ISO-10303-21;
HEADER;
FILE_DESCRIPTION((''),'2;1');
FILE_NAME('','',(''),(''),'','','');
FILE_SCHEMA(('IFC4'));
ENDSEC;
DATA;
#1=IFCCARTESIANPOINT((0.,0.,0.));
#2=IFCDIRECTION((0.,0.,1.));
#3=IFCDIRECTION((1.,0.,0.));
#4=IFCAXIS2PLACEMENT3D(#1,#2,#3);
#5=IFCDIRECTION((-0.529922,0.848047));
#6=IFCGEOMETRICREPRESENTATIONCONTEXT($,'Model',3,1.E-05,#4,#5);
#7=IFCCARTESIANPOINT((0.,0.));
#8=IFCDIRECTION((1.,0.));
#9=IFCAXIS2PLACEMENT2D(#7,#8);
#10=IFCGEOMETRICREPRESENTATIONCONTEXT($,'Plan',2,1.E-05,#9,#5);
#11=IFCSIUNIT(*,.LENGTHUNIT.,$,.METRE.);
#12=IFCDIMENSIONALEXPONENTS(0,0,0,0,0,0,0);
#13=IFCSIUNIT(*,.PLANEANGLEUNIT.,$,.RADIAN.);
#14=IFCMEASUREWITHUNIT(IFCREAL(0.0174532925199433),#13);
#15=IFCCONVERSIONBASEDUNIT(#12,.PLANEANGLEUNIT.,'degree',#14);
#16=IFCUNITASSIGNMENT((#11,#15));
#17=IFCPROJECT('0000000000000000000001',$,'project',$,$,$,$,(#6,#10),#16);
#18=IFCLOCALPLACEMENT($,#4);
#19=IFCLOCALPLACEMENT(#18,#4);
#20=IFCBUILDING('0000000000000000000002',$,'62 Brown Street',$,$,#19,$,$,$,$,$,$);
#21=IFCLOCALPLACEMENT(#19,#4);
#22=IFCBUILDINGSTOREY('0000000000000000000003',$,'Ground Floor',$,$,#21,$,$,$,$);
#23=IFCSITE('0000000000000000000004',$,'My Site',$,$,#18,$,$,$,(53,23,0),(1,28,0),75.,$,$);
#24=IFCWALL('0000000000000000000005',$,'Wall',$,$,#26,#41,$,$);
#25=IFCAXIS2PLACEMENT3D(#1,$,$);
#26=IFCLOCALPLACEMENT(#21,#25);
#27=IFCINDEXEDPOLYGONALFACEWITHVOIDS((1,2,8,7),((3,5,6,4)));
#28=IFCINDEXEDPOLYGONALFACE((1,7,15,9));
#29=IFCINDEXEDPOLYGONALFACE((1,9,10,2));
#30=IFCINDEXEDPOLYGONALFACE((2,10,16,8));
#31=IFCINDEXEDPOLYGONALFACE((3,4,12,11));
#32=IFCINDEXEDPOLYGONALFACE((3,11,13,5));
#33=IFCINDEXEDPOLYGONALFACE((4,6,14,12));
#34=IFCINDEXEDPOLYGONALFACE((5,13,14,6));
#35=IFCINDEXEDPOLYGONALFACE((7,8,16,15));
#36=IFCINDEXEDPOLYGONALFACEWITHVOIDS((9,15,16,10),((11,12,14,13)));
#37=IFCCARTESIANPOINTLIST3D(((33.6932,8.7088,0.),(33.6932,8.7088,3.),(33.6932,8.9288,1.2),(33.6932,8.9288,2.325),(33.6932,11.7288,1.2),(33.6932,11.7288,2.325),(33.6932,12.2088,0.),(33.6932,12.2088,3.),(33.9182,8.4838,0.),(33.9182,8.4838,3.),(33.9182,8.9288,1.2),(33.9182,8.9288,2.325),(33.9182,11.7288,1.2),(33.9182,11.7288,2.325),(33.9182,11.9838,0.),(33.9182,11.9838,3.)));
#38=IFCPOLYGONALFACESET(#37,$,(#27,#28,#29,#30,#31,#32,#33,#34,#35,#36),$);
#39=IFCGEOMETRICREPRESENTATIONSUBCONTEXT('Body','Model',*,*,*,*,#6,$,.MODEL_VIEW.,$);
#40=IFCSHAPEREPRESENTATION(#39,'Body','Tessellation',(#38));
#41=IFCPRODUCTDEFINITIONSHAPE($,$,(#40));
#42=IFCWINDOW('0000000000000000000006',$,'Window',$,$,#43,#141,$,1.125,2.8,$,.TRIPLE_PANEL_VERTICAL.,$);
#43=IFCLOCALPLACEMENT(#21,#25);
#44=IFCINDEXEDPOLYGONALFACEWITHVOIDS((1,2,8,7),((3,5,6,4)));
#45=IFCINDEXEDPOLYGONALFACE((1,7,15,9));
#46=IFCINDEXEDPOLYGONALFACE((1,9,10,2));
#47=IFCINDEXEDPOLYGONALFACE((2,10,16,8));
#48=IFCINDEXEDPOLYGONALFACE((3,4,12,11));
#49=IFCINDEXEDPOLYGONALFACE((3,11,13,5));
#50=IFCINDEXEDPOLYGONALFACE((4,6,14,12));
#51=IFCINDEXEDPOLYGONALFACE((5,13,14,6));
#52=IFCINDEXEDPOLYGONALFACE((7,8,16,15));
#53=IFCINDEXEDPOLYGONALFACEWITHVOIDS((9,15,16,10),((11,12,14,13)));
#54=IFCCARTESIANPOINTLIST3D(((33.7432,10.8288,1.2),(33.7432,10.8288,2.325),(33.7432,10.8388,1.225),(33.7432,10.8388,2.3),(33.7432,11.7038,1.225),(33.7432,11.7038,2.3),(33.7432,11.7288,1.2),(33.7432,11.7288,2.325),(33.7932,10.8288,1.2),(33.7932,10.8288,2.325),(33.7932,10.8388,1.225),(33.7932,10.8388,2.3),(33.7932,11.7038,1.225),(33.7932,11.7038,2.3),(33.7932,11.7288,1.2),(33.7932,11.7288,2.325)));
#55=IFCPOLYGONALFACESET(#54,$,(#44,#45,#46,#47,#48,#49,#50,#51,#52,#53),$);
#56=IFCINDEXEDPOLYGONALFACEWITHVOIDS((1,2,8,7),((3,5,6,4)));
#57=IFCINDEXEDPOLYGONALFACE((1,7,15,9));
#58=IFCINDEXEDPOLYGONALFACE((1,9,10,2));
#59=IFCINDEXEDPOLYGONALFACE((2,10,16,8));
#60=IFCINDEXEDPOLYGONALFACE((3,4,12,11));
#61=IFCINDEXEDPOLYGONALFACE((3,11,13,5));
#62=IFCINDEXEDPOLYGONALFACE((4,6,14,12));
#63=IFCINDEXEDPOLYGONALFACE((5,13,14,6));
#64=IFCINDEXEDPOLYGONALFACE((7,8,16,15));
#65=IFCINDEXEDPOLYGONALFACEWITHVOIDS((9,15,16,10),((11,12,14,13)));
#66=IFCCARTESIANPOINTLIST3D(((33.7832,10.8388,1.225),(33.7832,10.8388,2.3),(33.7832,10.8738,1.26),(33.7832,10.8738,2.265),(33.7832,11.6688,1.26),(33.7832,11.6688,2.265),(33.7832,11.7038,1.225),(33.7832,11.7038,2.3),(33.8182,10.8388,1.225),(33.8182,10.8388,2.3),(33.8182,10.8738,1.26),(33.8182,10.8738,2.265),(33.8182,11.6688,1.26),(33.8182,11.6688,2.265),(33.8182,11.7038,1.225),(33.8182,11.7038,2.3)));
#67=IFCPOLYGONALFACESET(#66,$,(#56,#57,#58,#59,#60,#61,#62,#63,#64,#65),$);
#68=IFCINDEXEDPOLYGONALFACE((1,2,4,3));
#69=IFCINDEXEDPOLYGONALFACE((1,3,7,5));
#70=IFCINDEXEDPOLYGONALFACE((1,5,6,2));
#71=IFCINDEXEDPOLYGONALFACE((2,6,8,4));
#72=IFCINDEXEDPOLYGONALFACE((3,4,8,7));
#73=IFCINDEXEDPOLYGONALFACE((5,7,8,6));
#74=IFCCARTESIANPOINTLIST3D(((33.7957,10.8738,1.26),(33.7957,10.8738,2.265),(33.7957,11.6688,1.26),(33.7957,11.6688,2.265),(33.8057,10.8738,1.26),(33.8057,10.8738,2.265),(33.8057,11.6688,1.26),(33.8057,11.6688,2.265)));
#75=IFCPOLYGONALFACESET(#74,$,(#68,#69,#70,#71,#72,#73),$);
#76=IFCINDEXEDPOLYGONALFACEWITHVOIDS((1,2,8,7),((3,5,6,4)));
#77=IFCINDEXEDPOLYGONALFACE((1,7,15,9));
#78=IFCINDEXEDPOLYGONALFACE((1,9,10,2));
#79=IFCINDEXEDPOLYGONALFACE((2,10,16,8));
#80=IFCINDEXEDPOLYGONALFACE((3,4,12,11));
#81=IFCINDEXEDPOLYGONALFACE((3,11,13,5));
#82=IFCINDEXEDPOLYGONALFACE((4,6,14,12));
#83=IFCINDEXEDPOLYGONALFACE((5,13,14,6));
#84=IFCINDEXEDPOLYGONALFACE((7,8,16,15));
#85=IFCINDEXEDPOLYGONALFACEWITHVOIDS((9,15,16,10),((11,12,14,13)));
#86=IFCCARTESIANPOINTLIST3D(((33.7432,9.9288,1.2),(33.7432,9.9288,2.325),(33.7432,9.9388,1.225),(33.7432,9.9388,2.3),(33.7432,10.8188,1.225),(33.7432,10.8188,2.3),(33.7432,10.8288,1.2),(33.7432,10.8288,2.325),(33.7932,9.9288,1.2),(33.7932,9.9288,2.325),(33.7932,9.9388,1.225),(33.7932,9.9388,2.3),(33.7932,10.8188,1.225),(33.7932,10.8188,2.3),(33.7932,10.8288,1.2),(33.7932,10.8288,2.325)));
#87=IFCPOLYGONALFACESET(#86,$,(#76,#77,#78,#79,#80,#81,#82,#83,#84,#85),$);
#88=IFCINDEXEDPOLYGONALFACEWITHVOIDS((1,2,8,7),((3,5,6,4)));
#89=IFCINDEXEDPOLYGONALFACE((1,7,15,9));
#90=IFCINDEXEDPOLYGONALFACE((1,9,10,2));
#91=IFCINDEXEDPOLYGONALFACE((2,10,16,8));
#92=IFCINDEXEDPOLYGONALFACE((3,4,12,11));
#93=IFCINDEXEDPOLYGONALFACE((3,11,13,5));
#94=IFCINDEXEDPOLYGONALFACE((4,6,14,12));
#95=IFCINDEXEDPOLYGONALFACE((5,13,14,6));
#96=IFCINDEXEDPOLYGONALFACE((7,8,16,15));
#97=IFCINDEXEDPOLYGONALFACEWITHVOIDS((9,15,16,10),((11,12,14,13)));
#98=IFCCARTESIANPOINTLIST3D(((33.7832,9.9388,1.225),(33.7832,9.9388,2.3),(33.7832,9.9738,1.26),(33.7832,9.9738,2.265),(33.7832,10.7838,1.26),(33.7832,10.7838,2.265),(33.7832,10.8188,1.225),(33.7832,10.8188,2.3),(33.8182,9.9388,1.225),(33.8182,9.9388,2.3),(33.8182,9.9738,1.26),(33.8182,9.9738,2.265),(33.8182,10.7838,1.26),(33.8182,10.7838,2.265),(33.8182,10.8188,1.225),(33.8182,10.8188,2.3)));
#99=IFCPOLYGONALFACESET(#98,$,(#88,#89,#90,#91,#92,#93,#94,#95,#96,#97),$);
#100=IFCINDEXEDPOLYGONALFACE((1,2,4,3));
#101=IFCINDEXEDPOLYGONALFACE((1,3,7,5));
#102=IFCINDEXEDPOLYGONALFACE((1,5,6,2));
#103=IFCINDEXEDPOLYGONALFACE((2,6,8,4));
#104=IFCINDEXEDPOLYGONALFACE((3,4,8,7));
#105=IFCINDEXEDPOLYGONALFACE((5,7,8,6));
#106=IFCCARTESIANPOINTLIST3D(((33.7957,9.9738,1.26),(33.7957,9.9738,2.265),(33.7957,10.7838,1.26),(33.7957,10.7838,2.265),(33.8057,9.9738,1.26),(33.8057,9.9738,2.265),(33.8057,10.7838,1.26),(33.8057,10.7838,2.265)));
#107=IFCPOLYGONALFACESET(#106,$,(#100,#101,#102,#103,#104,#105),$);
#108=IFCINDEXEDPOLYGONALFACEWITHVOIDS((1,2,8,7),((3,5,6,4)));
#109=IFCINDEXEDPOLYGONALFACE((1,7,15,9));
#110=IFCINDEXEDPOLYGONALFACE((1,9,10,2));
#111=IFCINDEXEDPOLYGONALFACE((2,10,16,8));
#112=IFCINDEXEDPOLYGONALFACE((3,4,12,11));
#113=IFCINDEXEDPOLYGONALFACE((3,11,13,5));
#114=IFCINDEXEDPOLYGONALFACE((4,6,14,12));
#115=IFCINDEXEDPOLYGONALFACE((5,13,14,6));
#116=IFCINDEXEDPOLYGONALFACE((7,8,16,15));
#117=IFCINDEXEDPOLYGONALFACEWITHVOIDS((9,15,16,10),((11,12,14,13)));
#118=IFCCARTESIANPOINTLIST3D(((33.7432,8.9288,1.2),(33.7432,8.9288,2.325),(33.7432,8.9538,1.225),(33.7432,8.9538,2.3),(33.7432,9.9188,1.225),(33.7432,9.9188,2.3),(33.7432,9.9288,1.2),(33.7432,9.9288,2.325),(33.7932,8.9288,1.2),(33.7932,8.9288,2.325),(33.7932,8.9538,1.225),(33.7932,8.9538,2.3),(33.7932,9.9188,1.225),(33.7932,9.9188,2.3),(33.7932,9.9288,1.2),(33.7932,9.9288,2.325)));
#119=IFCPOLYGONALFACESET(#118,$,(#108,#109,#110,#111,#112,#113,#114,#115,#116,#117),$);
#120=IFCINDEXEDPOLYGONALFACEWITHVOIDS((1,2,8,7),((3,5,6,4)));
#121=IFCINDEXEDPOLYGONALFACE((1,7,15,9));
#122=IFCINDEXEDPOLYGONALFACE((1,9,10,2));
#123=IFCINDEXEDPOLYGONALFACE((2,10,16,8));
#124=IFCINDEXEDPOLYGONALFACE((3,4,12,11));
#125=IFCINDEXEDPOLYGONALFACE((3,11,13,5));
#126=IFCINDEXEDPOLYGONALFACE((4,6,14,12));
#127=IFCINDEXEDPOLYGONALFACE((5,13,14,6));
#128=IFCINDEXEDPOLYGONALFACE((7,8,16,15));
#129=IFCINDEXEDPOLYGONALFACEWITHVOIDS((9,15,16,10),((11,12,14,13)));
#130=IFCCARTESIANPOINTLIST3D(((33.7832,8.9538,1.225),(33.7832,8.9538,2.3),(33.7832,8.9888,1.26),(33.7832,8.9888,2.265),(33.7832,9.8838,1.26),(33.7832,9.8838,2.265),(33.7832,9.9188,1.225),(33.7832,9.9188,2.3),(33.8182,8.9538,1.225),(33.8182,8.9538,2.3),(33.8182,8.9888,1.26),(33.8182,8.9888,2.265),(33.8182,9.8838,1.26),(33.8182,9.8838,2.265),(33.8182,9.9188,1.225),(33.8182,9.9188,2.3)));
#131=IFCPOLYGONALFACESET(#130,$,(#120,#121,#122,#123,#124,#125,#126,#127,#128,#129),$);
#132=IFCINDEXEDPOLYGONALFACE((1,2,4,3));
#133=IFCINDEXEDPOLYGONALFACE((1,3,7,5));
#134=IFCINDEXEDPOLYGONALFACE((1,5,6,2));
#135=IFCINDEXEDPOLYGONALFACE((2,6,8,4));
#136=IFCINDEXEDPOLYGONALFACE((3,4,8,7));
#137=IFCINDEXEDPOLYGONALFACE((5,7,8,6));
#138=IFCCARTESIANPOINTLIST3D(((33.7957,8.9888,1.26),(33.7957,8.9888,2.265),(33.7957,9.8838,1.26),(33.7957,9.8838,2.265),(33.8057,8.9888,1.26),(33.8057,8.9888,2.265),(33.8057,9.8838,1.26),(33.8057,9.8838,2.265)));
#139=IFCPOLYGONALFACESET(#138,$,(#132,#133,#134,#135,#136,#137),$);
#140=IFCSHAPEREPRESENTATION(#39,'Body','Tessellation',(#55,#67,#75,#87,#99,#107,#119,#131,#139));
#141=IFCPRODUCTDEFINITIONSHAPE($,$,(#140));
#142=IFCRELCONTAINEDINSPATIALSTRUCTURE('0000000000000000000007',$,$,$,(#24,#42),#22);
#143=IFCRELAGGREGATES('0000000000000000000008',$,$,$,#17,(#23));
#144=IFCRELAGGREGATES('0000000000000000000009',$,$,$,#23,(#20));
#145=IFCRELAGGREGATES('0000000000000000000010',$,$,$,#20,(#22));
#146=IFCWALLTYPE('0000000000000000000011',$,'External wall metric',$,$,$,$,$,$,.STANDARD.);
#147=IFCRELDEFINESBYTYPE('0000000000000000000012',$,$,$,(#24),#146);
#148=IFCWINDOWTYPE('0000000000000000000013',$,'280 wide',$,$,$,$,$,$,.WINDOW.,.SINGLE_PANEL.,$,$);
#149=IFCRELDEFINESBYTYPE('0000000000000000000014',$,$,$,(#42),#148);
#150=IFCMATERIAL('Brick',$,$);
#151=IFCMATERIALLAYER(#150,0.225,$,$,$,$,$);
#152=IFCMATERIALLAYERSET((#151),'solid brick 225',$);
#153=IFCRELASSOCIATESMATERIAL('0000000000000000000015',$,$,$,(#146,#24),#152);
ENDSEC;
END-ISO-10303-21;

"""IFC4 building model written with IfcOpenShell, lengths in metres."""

from ifc_helpers import new_model, entity, si_unit, converted_unit, direction, frame, origin_with_axes, origin_2d_with_axis, place, context, subcontext, project, spatial, line, indexed_curve, outline, extrude, clip, halfspace, shape, source, transform, mapped, material, layer, layer_set, layer_usage, type_object, type_shapes, element, fill, save


model = new_model("IFC4")

# Units and contexts
model_context = context("Model", 3, precision=1e-05, world=origin_with_axes(), true_north=direction((-0.529922, 0.848047)))
plan_context = context("Plan", 2, precision=1e-05, world=origin_2d_with_axis(), true_north=direction((-0.529922, 0.848047)))
body_context_1 = subcontext(model_context, "Body", "Model", "MODEL_VIEW")
body_context_2 = subcontext(plan_context, "Body", "Plan", "PLAN_VIEW")
ifc_project = project(units=[si_unit("LENGTHUNIT", "METRE"), converted_unit("PLANEANGLEUNIT", "degree", entity("IfcReal", 0.0174532925199433), si_unit("PLANEANGLEUNIT", "RADIAN"), dimensions=[0, 0, 0, 0, 0, 0, 0])], contexts=[model_context, plan_context])

# Site, building, storey
site_placement = place(None, origin_with_axes())
site = spatial("IfcSite", under=ifc_project, at=site_placement, Name="My Site", RefLatitude=(53, 23, 0), RefLongitude=(1, 28, 0), RefElevation=75.0)
building_placement = place(site_placement, origin_with_axes())
building = spatial("IfcBuilding", under=site, at=building_placement, Name="62 Brown Street")
storey_placement = place(building_placement, origin_with_axes())
storey = spatial("IfcBuildingStorey", under=building, at=storey_placement, Name="Ground Floor")

# Wall, opening, window
ifc_material_1 = material(Name="Brick")
ifc_layer_1 = layer(ifc_material_1, 0.225)
ifc_layer_set_1 = layer_set([ifc_layer_1], Name="solid brick 225")
ifc_layer_usage_1 = layer_usage(ifc_layer_set_1, "AXIS2", "POSITIVE", 0.0)
wall_type_1 = type_object("IfcWallType", Name="External wall metric", PredefinedType="STANDARD", material=ifc_layer_set_1)
wall_1_placement = place(storey_placement, frame((33.6932, 12.2088, 0.0), z_axis=(0.0, 0.0, 1.0), x_axis=(0.0, -1.0, 0.0)))
wall_1 = element("IfcWall", 1, at=wall_1_placement, inside=storey, type_object=wall_type_1, material=ifc_layer_usage_1, Name="Wall", context=body_context_1, shape_type="Clipping", body=[
    clip(clip(extrude(outline(indexed_curve([(0.0, 0.0), (0.0, 0.225), (3.725, 0.225), (3.725, 0.0), (0.0, 0.0)], self_intersect=False)), origin_with_axes(), (0.0, 0.0, 1.0), 3.0), halfspace(frame((0.0, 0.0, 0.0), z_axis=(-0.674995, 0.675001, 0.0), x_axis=(0.225, 0.224998, 0.0)), False)), halfspace(frame((3.5, 0.0, 0.0), z_axis=(0.674995, -0.674999, 0.0), x_axis=(0.225, 0.224998, 0.0)), False)),
])
shared_shape_1 = source(origin_with_axes(), body_context_1, "Body", "SweptSolid", [
    extrude(outline(indexed_curve([(0.0, 0.0), (2.8, 0.0), (2.8, 1.125), (0.0, 1.125)], segments=[line(1, 2, 3, 4, 1)])), frame((0.0, -0.1, 0.0), z_axis=(0.0, -1.0, 0.0), x_axis=(1.0, 0.0, 0.0)), (0.0, 0.0, -1.0), 0.425),
])
opening_1_placement = place(wall_1_placement, frame((0.48, 0.0, 1.2), z_axis=(0.0, 0.0, 1.0), x_axis=(1.0, 0.0, 0.0)))
opening_1 = element("IfcOpeningElement", 2, at=opening_1_placement, cuts=wall_1, PredefinedType="OPENING", context=body_context_1, shape_type="MappedRepresentation", body=[
    mapped(shared_shape_1, transform((0.0, 0.0, 0.0), x_axis=(1.0, 0.0, 0.0), y_axis=(0.0, 1.0, 0.0), z_axis=(0.0, 0.0, 1.0), scale=1.0)),
])
window_type_1 = type_object("IfcWindowType", Name="280 wide", PartitioningType="SINGLE_PANEL", PredefinedType="WINDOW")
shared_shape_2 = source(origin_with_axes(), body_context_1, "Body", "SweptSolid", [
    extrude(outline(indexed_curve([(0.0, 0.0), (0.9, 0.0), (0.9, 1.125), (0.0, 1.125)], segments=[line(1, 2, 3, 4, 1)]), holes=[indexed_curve([(0.025, 0.025), (0.89, 0.025), (0.89, 1.1), (0.025, 1.1)], segments=[line(1, 2, 3, 4, 1)])]), frame((0.0, 0.05, 0.0), z_axis=(0.0, -1.0, 0.0), x_axis=(1.0, 0.0, 0.0)), (0.0, 0.0, -1.0), 0.05),
    extrude(outline(indexed_curve([(0.0, 0.0), (0.865, 0.0), (0.865, 1.075), (0.0, 1.075)], segments=[line(1, 2, 3, 4, 1)]), holes=[indexed_curve([(0.035, 0.035), (0.83, 0.035), (0.83, 1.04), (0.035, 1.04)], segments=[line(1, 2, 3, 4, 1)])]), frame((0.025, 0.09, 0.025), z_axis=(0.0, -1.0, 0.0), x_axis=(1.0, 0.0, 0.0)), (0.0, 0.0, -1.0), 0.035),
    extrude(outline(indexed_curve([(0.035, 0.035), (0.83, 0.035), (0.83, 1.04), (0.035, 1.04)], segments=[line(1, 2, 3, 4, 1)])), frame((0.025, 0.1025, 0.025), z_axis=(0.0, -1.0, 0.0), x_axis=(1.0, 0.0, 0.0)), (0.0, 0.0, -1.0), 0.01),
    extrude(outline(indexed_curve([(0.0, 0.0), (0.9, 0.0), (0.9, 1.125), (0.0, 1.125)], segments=[line(1, 2, 3, 4, 1)]), holes=[indexed_curve([(0.01, 0.025), (0.89, 0.025), (0.89, 1.1), (0.01, 1.1)], segments=[line(1, 2, 3, 4, 1)])]), frame((0.9, 0.05, 0.0), z_axis=(0.0, -1.0, 0.0), x_axis=(1.0, 0.0, 0.0)), (0.0, 0.0, -1.0), 0.05),
    extrude(outline(indexed_curve([(0.0, 0.0), (0.88, 0.0), (0.88, 1.075), (0.0, 1.075)], segments=[line(1, 2, 3, 4, 1)]), holes=[indexed_curve([(0.035, 0.035), (0.845, 0.035), (0.845, 1.04), (0.035, 1.04)], segments=[line(1, 2, 3, 4, 1)])]), frame((0.91, 0.09, 0.025), z_axis=(0.0, -1.0, 0.0), x_axis=(1.0, 0.0, 0.0)), (0.0, 0.0, -1.0), 0.035),
    extrude(outline(indexed_curve([(0.035, 0.035), (0.845, 0.035), (0.845, 1.04), (0.035, 1.04)], segments=[line(1, 2, 3, 4, 1)])), frame((0.91, 0.1025, 0.025), z_axis=(0.0, -1.0, 0.0), x_axis=(1.0, 0.0, 0.0)), (0.0, 0.0, -1.0), 0.01),
    extrude(outline(indexed_curve([(0.0, 0.0), (1.0, 0.0), (1.0, 1.125), (0.0, 1.125)], segments=[line(1, 2, 3, 4, 1)]), holes=[indexed_curve([(0.01, 0.025), (0.975, 0.025), (0.975, 1.1), (0.01, 1.1)], segments=[line(1, 2, 3, 4, 1)])]), frame((1.8, 0.05, 0.0), z_axis=(0.0, -1.0, 0.0), x_axis=(1.0, 0.0, 0.0)), (0.0, 0.0, -1.0), 0.05),
    extrude(outline(indexed_curve([(0.0, 0.0), (0.965, 0.0), (0.965, 1.075), (0.0, 1.075)], segments=[line(1, 2, 3, 4, 1)]), holes=[indexed_curve([(0.035, 0.035), (0.93, 0.035), (0.93, 1.04), (0.035, 1.04)], segments=[line(1, 2, 3, 4, 1)])]), frame((1.81, 0.09, 0.025), z_axis=(0.0, -1.0, 0.0), x_axis=(1.0, 0.0, 0.0)), (0.0, 0.0, -1.0), 0.035),
    extrude(outline(indexed_curve([(0.035, 0.035), (0.93, 0.035), (0.93, 1.04), (0.035, 1.04)], segments=[line(1, 2, 3, 4, 1)])), frame((1.81, 0.1025, 0.025), z_axis=(0.0, -1.0, 0.0), x_axis=(1.0, 0.0, 0.0)), (0.0, 0.0, -1.0), 0.01),
])
shared_shape_3 = source(origin_with_axes(), body_context_2, "Body", "Curve2D", [
    entity("IfcIndexedPolyCurve", entity("IfcCartesianPointList2D", [[0.025, 0.05], [0.89, 0.05]])),
    entity("IfcIndexedPolyCurve", entity("IfcCartesianPointList2D", [[0.0, 0.1], [0.025, 0.1], [0.025, 0.05], [0.0, 0.05]]), [entity("IfcLineIndex", [1, 2, 3, 4, 1])]),
    entity("IfcIndexedPolyCurve", entity("IfcCartesianPointList2D", [[0.9, 0.1], [0.89, 0.1], [0.89, 0.05], [0.9, 0.05]])),
    entity("IfcIndexedPolyCurve", entity("IfcCartesianPointList2D", [[0.025, 0.09], [0.06, 0.09], [0.06, 0.125], [0.025, 0.125]]), [entity("IfcLineIndex", [1, 2, 3, 4, 1])]),
    entity("IfcIndexedPolyCurve", entity("IfcCartesianPointList2D", [[0.89, 0.09], [0.855, 0.09], [0.855, 0.125], [0.89, 0.125]]), [entity("IfcLineIndex", [1, 2, 3, 4, 1])]),
    entity("IfcIndexedPolyCurve", entity("IfcCartesianPointList2D", [[0.06, 0.09], [0.855, 0.09]])),
    entity("IfcIndexedPolyCurve", entity("IfcCartesianPointList2D", [[0.06, 0.125], [0.855, 0.125]])),
    entity("IfcIndexedPolyCurve", entity("IfcCartesianPointList2D", [[0.06, 0.1075], [0.855, 0.1075]])),
    entity("IfcIndexedPolyCurve", entity("IfcCartesianPointList2D", [[0.91, 0.05], [1.79, 0.05]])),
    entity("IfcIndexedPolyCurve", entity("IfcCartesianPointList2D", [[0.9, 0.1], [0.91, 0.1], [0.91, 0.05], [0.9, 0.05]])),
    entity("IfcIndexedPolyCurve", entity("IfcCartesianPointList2D", [[1.8, 0.1], [1.79, 0.1], [1.79, 0.05], [1.8, 0.05]])),
    entity("IfcIndexedPolyCurve", entity("IfcCartesianPointList2D", [[0.91, 0.09], [0.945, 0.09], [0.945, 0.125], [0.91, 0.125]]), [entity("IfcLineIndex", [1, 2, 3, 4, 1])]),
    entity("IfcIndexedPolyCurve", entity("IfcCartesianPointList2D", [[1.79, 0.09], [1.755, 0.09], [1.755, 0.125], [1.79, 0.125]]), [entity("IfcLineIndex", [1, 2, 3, 4, 1])]),
    entity("IfcIndexedPolyCurve", entity("IfcCartesianPointList2D", [[0.945, 0.09], [1.755, 0.09]])),
    entity("IfcIndexedPolyCurve", entity("IfcCartesianPointList2D", [[0.945, 0.125], [1.755, 0.125]])),
    entity("IfcIndexedPolyCurve", entity("IfcCartesianPointList2D", [[0.945, 0.1075], [1.755, 0.1075]])),
    entity("IfcIndexedPolyCurve", entity("IfcCartesianPointList2D", [[1.81, 0.05], [2.775, 0.05]])),
    entity("IfcIndexedPolyCurve", entity("IfcCartesianPointList2D", [[1.8, 0.1], [1.81, 0.1], [1.81, 0.05], [1.8, 0.05]])),
    entity("IfcIndexedPolyCurve", entity("IfcCartesianPointList2D", [[2.8, 0.1], [2.775, 0.1], [2.775, 0.05], [2.8, 0.05]]), [entity("IfcLineIndex", [1, 2, 3, 4, 1])]),
    entity("IfcIndexedPolyCurve", entity("IfcCartesianPointList2D", [[1.81, 0.09], [1.845, 0.09], [1.845, 0.125], [1.81, 0.125]]), [entity("IfcLineIndex", [1, 2, 3, 4, 1])]),
    entity("IfcIndexedPolyCurve", entity("IfcCartesianPointList2D", [[2.775, 0.09], [2.74, 0.09], [2.74, 0.125], [2.775, 0.125]]), [entity("IfcLineIndex", [1, 2, 3, 4, 1])]),
    entity("IfcIndexedPolyCurve", entity("IfcCartesianPointList2D", [[1.845, 0.09], [2.74, 0.09]])),
    entity("IfcIndexedPolyCurve", entity("IfcCartesianPointList2D", [[1.845, 0.125], [2.74, 0.125]])),
    entity("IfcIndexedPolyCurve", entity("IfcCartesianPointList2D", [[1.845, 0.1075], [2.74, 0.1075]])),
])
type_shapes(window_type_1, [shared_shape_2, shared_shape_3])
window_1_placement = place(opening_1_placement, frame((0.0, 0.0, 0.0), z_axis=(0.0, 0.0, 1.0), x_axis=(1.0, 0.0, 0.0)))
window_1 = element("IfcWindow", 3, at=window_1_placement, inside=storey, type_object=window_type_1, Name="Window", OverallHeight=1.125, OverallWidth=2.8, PartitioningType="TRIPLE_PANEL_VERTICAL", shapes=[
    shape(body_context_1, "Body", "MappedRepresentation", [mapped(shared_shape_2, transform((0.0, 0.0, 0.0), x_axis=(1.0, 0.0, 0.0), y_axis=(0.0, 1.0, 0.0), z_axis=(0.0, 0.0, 1.0), scale=1.0))]),
    shape(body_context_2, "Body", "MappedRepresentation", [mapped(shared_shape_3, transform((0.0, 0.0, 0.0), x_axis=(1.0, 0.0, 0.0), y_axis=(0.0, 1.0, 0.0), z_axis=(0.0, 0.0, 1.0), scale=1.0))]),
])
fill(opening_1, window_1)

save(model, "model.ifc")
